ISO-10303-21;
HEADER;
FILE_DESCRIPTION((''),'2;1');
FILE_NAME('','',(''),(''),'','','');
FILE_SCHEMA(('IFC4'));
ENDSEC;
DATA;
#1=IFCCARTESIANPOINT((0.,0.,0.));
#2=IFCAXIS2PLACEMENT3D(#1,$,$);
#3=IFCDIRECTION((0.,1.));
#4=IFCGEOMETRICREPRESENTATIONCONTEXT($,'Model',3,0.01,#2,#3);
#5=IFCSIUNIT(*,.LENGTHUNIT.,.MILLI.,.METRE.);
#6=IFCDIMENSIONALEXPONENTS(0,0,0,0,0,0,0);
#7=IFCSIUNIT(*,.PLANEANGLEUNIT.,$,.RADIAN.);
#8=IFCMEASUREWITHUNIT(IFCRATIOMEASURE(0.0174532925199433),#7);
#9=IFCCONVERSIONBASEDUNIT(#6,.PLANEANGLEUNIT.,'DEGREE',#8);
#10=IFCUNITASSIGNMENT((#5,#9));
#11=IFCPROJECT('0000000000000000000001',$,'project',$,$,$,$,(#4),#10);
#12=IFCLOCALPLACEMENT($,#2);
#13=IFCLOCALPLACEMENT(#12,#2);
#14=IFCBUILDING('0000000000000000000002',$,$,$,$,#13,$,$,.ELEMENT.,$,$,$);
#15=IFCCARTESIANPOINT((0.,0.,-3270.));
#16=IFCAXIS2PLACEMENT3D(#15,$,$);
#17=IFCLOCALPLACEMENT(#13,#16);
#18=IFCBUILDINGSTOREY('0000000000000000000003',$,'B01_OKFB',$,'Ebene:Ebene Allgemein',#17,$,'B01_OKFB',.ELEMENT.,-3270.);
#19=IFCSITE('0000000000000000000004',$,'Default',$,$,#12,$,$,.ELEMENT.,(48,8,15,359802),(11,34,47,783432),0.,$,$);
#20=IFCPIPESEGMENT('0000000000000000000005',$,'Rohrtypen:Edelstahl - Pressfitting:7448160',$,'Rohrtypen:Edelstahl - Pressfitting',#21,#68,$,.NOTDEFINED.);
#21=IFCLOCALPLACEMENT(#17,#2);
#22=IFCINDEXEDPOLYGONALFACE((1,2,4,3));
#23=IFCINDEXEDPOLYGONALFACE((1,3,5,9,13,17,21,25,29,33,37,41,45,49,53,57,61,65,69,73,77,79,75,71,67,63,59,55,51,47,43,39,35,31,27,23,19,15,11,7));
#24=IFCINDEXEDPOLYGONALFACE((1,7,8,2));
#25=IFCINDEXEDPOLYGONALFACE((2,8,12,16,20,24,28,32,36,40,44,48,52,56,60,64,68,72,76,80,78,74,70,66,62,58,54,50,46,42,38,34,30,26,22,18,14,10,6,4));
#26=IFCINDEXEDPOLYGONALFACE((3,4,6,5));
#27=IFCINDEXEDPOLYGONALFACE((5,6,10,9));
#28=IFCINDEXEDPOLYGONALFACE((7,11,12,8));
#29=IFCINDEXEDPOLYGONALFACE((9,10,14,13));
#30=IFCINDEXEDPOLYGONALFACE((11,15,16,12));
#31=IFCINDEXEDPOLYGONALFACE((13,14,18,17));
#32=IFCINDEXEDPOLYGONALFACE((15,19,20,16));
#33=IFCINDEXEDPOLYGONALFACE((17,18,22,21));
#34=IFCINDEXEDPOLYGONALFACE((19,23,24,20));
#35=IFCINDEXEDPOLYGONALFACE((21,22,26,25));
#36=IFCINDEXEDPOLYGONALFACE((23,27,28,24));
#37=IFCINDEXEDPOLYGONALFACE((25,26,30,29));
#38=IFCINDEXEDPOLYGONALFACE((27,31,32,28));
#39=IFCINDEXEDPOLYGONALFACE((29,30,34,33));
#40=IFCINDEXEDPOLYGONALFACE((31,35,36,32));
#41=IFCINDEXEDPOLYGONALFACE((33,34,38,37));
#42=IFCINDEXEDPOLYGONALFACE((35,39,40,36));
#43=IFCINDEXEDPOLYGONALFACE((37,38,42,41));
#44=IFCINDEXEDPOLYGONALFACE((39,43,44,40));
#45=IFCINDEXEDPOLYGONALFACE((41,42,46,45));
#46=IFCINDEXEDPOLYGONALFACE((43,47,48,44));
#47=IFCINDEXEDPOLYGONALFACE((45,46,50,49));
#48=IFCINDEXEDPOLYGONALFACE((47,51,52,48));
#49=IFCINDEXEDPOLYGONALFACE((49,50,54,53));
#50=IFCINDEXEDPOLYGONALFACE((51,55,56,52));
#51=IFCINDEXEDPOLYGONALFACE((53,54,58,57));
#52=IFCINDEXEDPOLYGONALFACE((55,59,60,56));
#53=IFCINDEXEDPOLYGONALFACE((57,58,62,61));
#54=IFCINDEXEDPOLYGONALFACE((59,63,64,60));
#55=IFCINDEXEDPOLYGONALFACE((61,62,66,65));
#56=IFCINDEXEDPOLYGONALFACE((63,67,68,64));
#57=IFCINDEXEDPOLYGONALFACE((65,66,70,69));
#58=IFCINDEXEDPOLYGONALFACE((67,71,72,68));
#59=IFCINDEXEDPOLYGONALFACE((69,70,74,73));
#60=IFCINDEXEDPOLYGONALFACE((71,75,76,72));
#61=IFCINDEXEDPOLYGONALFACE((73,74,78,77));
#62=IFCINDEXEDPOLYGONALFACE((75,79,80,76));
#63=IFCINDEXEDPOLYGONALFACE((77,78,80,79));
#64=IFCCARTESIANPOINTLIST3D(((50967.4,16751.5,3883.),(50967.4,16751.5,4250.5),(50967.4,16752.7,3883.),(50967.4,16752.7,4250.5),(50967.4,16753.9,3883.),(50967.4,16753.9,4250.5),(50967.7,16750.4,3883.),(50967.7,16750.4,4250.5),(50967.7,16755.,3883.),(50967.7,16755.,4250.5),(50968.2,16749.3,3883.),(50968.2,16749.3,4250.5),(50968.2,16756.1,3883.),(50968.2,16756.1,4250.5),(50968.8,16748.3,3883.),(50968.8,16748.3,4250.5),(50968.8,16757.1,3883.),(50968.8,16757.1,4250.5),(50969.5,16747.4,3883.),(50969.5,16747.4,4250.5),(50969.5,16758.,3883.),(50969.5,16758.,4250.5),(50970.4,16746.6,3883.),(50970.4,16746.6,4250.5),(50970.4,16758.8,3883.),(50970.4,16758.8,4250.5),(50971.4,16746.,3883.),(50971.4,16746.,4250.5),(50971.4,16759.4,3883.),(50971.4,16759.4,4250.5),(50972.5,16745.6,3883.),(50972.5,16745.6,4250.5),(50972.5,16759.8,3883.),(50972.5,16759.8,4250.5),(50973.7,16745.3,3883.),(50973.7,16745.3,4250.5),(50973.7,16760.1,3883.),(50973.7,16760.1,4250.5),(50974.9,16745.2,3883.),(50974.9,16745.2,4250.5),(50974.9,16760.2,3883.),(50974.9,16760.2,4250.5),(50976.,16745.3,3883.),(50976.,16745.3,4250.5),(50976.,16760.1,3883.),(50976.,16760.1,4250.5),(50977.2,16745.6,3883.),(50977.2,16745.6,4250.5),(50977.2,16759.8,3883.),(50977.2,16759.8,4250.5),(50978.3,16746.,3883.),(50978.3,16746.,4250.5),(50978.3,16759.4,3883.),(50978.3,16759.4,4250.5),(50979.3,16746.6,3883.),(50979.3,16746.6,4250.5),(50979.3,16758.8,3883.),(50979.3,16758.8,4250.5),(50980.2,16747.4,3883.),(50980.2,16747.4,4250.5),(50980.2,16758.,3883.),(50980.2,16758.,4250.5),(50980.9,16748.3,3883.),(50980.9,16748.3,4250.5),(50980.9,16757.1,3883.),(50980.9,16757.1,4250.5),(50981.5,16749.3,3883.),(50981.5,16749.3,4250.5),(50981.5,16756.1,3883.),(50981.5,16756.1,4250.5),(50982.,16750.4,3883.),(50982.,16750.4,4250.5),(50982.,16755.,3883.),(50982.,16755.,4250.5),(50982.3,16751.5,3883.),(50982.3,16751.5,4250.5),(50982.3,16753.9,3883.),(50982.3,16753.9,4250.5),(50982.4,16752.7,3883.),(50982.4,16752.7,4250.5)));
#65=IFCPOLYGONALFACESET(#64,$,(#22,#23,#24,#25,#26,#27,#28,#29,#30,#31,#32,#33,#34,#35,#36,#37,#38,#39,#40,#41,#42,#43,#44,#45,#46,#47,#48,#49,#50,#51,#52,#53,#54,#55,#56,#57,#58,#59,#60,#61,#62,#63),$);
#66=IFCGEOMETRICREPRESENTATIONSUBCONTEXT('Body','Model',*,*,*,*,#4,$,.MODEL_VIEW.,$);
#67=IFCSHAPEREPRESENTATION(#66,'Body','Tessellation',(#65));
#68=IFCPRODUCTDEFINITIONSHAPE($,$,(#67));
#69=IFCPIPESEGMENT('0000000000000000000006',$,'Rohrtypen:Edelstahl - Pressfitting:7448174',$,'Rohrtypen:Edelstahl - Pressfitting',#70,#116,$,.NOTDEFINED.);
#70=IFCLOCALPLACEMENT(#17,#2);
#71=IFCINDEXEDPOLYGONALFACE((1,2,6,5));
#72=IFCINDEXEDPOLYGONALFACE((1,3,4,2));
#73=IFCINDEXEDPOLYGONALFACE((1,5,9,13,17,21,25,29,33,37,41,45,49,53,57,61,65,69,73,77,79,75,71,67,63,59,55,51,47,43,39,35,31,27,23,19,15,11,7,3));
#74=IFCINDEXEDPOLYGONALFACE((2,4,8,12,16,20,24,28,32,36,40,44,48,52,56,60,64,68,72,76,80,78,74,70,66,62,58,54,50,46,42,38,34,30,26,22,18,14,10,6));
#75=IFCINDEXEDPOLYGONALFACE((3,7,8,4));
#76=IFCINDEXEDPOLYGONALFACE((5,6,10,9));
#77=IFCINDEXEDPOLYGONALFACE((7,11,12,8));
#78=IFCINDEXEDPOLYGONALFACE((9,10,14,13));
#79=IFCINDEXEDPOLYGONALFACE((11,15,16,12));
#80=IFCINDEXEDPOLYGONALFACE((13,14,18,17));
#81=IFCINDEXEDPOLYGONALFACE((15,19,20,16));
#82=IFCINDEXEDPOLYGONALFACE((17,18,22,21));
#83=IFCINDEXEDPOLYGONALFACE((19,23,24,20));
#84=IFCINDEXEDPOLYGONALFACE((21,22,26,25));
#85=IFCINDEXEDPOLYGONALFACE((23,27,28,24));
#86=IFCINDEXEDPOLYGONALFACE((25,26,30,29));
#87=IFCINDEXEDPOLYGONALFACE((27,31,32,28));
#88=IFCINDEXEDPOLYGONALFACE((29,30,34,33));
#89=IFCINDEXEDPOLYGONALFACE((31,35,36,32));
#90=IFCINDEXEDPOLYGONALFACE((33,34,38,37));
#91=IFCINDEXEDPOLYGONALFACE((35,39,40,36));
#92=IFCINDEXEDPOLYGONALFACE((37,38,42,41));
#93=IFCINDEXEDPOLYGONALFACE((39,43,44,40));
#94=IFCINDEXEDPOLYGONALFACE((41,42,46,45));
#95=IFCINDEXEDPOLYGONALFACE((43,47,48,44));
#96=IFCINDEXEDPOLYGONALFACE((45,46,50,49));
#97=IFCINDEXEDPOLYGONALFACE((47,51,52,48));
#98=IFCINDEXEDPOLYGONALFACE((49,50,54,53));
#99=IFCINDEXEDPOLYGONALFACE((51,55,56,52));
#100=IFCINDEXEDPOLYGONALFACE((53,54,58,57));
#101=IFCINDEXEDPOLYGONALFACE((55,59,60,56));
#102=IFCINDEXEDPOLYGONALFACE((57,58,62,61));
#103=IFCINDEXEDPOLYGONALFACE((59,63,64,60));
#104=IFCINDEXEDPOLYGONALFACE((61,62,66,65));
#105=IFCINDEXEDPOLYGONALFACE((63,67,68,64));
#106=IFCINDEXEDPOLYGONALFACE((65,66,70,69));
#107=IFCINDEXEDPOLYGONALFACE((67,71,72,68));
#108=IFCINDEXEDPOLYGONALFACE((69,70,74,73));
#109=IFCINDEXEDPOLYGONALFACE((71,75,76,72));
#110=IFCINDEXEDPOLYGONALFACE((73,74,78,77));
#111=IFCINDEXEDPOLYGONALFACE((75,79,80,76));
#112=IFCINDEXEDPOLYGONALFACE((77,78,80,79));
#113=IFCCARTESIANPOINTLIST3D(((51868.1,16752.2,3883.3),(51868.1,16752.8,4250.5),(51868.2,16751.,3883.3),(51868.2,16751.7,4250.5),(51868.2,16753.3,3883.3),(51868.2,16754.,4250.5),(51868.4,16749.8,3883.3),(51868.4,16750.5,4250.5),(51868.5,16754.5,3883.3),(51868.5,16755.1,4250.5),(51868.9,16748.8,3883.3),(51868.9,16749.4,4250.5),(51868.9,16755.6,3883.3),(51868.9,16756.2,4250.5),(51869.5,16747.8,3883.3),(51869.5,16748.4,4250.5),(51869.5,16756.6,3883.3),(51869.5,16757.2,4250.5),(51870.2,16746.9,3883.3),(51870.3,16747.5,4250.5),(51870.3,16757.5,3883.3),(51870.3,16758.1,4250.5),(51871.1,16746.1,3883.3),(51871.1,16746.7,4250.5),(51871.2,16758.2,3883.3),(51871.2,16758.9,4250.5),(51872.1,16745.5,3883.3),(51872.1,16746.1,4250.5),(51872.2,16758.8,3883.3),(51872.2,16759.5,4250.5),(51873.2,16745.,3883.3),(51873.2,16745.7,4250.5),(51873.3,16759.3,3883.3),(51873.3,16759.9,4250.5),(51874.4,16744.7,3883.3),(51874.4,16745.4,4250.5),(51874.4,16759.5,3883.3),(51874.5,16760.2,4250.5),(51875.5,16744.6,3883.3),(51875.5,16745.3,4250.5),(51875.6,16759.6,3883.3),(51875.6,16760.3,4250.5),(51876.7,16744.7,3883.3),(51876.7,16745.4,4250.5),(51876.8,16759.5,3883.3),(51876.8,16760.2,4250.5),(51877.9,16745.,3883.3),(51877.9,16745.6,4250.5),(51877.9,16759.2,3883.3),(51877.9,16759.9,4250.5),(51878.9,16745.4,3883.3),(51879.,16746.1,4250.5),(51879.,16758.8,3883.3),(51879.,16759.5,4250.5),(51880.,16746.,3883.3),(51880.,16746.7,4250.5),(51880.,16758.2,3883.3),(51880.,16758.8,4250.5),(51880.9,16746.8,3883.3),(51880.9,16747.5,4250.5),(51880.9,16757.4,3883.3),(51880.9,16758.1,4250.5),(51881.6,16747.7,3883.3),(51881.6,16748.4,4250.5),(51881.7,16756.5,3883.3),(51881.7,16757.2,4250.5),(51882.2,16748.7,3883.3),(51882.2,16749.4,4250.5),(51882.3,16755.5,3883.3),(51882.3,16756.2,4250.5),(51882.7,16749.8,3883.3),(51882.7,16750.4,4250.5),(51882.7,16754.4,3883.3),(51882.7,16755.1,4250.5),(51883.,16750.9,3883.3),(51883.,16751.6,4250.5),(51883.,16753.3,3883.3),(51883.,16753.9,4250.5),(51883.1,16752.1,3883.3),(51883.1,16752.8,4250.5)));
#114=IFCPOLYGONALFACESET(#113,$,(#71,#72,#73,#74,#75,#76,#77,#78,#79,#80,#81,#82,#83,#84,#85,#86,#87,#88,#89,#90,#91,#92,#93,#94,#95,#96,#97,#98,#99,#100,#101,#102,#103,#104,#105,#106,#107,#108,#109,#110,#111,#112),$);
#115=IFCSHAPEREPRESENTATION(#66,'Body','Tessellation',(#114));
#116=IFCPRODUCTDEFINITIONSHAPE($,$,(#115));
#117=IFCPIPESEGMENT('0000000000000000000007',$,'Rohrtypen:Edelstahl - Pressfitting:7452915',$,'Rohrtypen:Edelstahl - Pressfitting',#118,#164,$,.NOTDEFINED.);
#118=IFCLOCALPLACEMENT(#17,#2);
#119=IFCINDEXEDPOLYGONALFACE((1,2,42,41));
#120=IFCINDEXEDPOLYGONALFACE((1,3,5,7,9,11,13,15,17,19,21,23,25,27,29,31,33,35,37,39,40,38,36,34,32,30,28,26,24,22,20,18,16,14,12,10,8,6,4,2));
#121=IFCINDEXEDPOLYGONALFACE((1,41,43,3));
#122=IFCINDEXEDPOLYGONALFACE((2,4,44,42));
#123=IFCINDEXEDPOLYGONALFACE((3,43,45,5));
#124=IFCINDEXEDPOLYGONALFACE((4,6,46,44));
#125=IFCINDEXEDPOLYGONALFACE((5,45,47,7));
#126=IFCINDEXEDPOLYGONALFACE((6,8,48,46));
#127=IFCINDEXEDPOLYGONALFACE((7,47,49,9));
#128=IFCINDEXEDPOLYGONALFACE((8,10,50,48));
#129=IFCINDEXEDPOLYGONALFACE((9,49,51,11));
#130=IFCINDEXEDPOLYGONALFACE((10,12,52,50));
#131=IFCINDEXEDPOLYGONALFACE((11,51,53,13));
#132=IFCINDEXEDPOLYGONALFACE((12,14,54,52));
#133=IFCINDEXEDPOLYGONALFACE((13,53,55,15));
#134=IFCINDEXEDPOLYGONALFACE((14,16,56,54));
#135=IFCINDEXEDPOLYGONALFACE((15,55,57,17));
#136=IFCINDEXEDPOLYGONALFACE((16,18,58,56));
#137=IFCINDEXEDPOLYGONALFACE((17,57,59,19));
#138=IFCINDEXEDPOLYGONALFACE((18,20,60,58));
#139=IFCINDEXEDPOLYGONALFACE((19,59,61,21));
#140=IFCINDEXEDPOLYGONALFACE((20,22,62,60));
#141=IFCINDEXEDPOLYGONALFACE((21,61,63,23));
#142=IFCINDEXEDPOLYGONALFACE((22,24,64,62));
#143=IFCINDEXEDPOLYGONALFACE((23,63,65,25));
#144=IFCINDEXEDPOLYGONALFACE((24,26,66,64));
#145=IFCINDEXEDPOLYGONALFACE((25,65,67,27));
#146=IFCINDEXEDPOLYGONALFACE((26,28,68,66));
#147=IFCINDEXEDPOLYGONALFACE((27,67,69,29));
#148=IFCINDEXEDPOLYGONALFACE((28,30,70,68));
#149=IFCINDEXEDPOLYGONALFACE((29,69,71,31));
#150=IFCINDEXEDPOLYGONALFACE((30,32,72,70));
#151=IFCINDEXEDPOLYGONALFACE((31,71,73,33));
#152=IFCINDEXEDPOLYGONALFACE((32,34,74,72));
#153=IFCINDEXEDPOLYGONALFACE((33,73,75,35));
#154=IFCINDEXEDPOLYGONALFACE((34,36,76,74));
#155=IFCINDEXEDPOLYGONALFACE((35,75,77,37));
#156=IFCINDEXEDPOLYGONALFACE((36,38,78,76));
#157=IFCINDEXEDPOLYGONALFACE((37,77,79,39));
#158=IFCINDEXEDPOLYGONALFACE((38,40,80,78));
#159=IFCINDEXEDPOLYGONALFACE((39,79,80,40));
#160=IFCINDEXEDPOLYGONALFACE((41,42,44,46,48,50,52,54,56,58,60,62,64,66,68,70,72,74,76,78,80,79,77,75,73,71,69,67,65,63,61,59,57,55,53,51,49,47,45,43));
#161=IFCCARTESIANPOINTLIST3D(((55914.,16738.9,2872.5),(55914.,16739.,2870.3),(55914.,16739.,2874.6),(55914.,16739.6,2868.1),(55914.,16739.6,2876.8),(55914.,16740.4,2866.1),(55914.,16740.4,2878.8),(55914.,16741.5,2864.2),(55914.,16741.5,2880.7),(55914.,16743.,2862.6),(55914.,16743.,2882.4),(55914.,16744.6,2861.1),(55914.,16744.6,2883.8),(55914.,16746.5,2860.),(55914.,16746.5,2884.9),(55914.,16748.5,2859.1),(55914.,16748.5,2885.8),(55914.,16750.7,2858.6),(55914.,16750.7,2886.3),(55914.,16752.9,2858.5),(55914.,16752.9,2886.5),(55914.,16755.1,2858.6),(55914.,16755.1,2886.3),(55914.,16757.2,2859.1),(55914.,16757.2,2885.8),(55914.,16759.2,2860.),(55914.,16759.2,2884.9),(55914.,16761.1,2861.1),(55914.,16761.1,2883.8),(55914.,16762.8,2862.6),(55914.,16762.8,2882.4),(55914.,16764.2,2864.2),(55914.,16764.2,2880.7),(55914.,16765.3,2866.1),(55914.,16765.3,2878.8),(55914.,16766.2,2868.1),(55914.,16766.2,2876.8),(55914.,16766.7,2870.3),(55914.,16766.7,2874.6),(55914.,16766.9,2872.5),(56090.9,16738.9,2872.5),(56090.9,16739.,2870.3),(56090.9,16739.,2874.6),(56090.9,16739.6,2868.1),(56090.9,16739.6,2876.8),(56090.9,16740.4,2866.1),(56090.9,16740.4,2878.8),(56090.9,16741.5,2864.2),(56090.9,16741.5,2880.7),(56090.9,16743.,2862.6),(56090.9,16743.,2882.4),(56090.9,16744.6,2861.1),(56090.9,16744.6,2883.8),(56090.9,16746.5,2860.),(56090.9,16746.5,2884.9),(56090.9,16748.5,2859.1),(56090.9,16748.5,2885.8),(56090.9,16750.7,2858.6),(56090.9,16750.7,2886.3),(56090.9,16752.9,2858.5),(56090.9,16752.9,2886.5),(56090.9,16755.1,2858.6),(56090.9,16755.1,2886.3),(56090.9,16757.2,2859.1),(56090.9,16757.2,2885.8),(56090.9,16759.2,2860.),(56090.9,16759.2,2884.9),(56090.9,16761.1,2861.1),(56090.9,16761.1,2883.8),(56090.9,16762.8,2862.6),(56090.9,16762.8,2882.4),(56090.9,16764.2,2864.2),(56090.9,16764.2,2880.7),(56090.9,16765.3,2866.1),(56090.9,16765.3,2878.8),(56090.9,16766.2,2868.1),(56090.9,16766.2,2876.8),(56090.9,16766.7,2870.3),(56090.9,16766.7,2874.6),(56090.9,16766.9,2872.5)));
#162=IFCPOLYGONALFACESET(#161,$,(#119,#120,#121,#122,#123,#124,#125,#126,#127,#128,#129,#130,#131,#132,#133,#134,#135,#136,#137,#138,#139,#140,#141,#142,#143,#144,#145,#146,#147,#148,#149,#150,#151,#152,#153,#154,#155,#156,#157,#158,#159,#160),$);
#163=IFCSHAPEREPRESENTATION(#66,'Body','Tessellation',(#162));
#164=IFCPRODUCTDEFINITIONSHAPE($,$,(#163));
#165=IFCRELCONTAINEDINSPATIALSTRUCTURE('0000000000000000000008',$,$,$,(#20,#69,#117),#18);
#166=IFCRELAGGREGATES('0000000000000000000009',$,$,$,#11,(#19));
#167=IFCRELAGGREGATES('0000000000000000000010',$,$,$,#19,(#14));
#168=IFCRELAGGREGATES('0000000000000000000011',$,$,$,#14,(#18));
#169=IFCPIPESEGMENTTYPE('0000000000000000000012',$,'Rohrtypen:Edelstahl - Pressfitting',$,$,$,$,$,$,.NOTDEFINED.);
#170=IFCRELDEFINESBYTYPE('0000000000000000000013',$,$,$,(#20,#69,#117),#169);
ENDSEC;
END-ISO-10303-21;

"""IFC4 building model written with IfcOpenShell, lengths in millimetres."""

from ifc_helpers import new_model, entity, si_unit, converted_unit, direction, frame, origin, place, context, subcontext, project, spatial, indexed_curve, outline, extrude, type_object, element, save


model = new_model("IFC4")

# Units and contexts
model_context = context("Model", 3, precision=0.01, world=origin(), true_north=direction((0.0, 1.0)))
body_context = subcontext(model_context, "Body", "Model", "MODEL_VIEW")
ifc_project = project(units=[si_unit("LENGTHUNIT", "METRE", prefix="MILLI"), converted_unit("PLANEANGLEUNIT", "DEGREE", entity("IfcRatioMeasure", 0.0174532925199433), si_unit("PLANEANGLEUNIT", "RADIAN"), dimensions=[0, 0, 0, 0, 0, 0, 0])], contexts=[model_context])

# Site, building, storey
site_placement = place(None, origin())
site = spatial("IfcSite", under=ifc_project, at=site_placement, Name="Default", CompositionType="ELEMENT", RefLatitude=(48, 8, 15, 359802), RefLongitude=(11, 34, 47, 783432), RefElevation=0.0)
building_placement = place(site_placement, origin())
building = spatial("IfcBuilding", under=site, at=building_placement, CompositionType="ELEMENT")
storey_placement = place(building_placement, frame((0.0, 0.0, -3270.0)))
storey = spatial("IfcBuildingStorey", under=building, at=storey_placement, Name="B01_OKFB", ObjectType="Ebene:Ebene Allgemein", LongName="B01_OKFB", CompositionType="ELEMENT", Elevation=-3270.0)

# Pipe segments
pipe_segment_type_1 = type_object("IfcPipeSegmentType", Name="Rohrtypen:Edelstahl - Pressfitting", PredefinedType="NOTDEFINED")
pipe_segment_1_placement = place(storey_placement, origin())
element("IfcPipeSegment", 1, at=pipe_segment_1_placement, inside=storey, type_object=pipe_segment_type_1, Name="Rohrtypen:Edelstahl - Pressfitting:7448160", ObjectType="Rohrtypen:Edelstahl - Pressfitting", PredefinedType="NOTDEFINED", context=body_context, shape_type="SweptSolid", body=[
    extrude(outline(indexed_curve([(7.5, 0.0), (7.4, 1.2), (7.1, 2.3), (6.7, 3.4), (6.1, 4.4), (5.3, 5.3), (4.4, 6.1), (3.4, 6.7), (2.3, 7.1), (1.2, 7.4), (0.0, 7.5), (-1.2, 7.4), (-2.3, 7.1), (-3.4, 6.7), (-4.4, 6.1), (-5.3, 5.3), (-6.1, 4.4), (-6.7, 3.4), (-7.1, 2.3), (-7.4, 1.2), (-7.5, 0.0), (-7.4, -1.2), (-7.1, -2.3), (-6.7, -3.4), (-6.1, -4.4), (-5.3, -5.3), (-4.4, -6.1), (-3.4, -6.7), (-2.3, -7.1), (-1.2, -7.4), (0.0, -7.5), (1.2, -7.4), (2.3, -7.1), (3.4, -6.7), (4.4, -6.1), (5.3, -5.3), (6.1, -4.4), (6.7, -3.4), (7.1, -2.3), (7.4, -1.2), (7.5, 0.0)], self_intersect=False)), frame((50974.9, 16752.7, 3883.0), z_axis=(0.0, 0.0, 1.0), x_axis=(-1.0, 0.0, 0.0)), (0.0, 0.0, 1.0), 367.5),
])
pipe_segment_2_placement = place(storey_placement, origin())
element("IfcPipeSegment", 2, at=pipe_segment_2_placement, inside=storey, type_object=pipe_segment_type_1, Name="Rohrtypen:Edelstahl - Pressfitting:7448174", ObjectType="Rohrtypen:Edelstahl - Pressfitting", PredefinedType="NOTDEFINED", context=body_context, shape_type="SweptSolid", body=[
    extrude(outline(indexed_curve([(7.5, 0.0), (7.4, 1.2), (7.1, 2.3), (6.7, 3.4), (6.1, 4.4), (5.3, 5.3), (4.4, 6.1), (3.4, 6.7), (2.3, 7.1), (1.2, 7.4), (0.0, 7.5), (-1.2, 7.4), (-2.3, 7.1), (-3.4, 6.7), (-4.4, 6.1), (-5.3, 5.3), (-6.1, 4.4), (-6.7, 3.4), (-7.1, 2.3), (-7.4, 1.2), (-7.5, 0.0), (-7.4, -1.2), (-7.1, -2.3), (-6.7, -3.4), (-6.1, -4.4), (-5.3, -5.3), (-4.4, -6.1), (-3.4, -6.7), (-2.3, -7.1), (-1.2, -7.4), (0.0, -7.5), (1.2, -7.4), (2.3, -7.1), (3.4, -6.7), (4.4, -6.1), (5.3, -5.3), (6.1, -4.4), (6.7, -3.4), (7.1, -2.3), (7.4, -1.2), (7.5, 0.0)], self_intersect=False)), frame((51875.6, 16752.1, 3883.3), z_axis=(0.00001, 0.00181, 0.999998), x_axis=(0.999985, -0.005406, 0.0)), (0.0, 0.0, 1.0), 367.2),
])
pipe_segment_3_placement = place(storey_placement, origin())
element("IfcPipeSegment", 3, at=pipe_segment_3_placement, inside=storey, type_object=pipe_segment_type_1, Name="Rohrtypen:Edelstahl - Pressfitting:7452915", ObjectType="Rohrtypen:Edelstahl - Pressfitting", PredefinedType="NOTDEFINED", context=body_context, shape_type="SweptSolid", body=[
    extrude(outline(indexed_curve([(14.0, 0.0), (13.8, 2.2), (13.3, 4.3), (12.5, 6.4), (11.3, 8.2), (9.9, 9.9), (8.2, 11.3), (6.4, 12.5), (4.3, 13.3), (2.2, 13.8), (0.0, 14.0), (-2.2, 13.8), (-4.3, 13.3), (-6.4, 12.5), (-8.2, 11.3), (-9.9, 9.9), (-11.3, 8.2), (-12.5, 6.4), (-13.3, 4.3), (-13.8, 2.2), (-14.0, 0.0), (-13.8, -2.2), (-13.3, -4.3), (-12.5, -6.4), (-11.3, -8.2), (-9.9, -9.9), (-8.2, -11.3), (-6.4, -12.5), (-4.3, -13.3), (-2.2, -13.8), (0.0, -14.0), (2.2, -13.8), (4.3, -13.3), (6.4, -12.5), (8.2, -11.3), (9.9, -9.9), (11.3, -8.2), (12.5, -6.4), (13.3, -4.3), (13.8, -2.2), (14.0, 0.0)], self_intersect=False)), frame((55914.0, 16752.9, 2872.5), z_axis=(1.0, 0.0, 0.0), x_axis=(0.0, 1.0, 0.0)), (0.0, 0.0, 1.0), 176.9),
])

save(model, "model.ifc")
